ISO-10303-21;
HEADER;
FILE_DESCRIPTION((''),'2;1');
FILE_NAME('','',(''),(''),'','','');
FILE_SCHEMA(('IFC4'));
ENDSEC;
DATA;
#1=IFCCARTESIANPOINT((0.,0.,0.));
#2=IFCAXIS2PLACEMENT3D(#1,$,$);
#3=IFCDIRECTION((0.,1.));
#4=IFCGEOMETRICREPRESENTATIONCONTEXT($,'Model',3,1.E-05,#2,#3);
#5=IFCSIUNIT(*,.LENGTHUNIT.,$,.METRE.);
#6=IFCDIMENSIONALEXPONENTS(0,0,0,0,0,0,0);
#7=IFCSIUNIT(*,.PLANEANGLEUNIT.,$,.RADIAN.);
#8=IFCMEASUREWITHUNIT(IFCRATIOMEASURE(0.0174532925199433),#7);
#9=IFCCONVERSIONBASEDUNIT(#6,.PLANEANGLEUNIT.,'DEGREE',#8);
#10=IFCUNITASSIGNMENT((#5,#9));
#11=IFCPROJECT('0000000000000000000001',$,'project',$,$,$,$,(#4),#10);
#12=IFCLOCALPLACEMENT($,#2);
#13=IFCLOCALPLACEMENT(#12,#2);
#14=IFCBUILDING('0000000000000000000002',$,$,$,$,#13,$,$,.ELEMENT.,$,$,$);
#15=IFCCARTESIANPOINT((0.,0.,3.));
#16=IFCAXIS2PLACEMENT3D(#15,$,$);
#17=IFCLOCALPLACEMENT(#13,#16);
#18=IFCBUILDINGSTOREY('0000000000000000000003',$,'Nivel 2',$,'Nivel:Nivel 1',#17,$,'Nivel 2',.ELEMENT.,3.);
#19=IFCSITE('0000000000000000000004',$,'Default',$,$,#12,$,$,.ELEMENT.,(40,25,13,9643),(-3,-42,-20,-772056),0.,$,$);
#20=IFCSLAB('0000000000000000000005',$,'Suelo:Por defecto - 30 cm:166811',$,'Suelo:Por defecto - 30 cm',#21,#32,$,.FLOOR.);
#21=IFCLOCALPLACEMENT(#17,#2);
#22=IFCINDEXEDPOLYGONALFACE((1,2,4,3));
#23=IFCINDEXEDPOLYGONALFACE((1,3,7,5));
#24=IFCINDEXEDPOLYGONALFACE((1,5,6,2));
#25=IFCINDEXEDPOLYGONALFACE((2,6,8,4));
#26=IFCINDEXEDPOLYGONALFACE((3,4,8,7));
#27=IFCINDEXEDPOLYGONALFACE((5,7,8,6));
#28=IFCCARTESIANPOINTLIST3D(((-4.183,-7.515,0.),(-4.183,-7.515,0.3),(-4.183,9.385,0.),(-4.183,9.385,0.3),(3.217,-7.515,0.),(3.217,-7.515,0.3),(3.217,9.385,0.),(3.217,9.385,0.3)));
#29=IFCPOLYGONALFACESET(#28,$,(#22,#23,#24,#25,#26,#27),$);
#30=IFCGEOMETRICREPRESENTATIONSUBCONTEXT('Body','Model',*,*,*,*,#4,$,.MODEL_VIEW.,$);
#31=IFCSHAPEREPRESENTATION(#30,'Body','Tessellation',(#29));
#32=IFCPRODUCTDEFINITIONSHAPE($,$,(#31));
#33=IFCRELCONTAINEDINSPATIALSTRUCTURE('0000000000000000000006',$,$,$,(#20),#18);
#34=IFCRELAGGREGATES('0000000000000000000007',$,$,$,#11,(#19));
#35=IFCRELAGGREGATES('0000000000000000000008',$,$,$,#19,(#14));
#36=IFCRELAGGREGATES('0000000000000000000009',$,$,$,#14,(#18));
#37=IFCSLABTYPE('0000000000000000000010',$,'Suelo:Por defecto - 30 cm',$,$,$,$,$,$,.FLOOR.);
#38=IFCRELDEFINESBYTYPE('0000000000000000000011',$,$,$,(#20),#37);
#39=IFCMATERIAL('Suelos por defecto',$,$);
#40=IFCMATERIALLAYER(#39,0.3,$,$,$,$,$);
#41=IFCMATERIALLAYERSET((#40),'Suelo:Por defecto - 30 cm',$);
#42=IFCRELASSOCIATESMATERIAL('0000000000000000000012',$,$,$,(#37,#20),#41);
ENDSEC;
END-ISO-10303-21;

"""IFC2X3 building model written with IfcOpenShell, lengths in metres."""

from ifc_helpers import new_model, entity, si_unit, converted_unit, direction, frame, origin, origin_2d_with_axis, place, context, subcontext, project, spatial, rectangle, extrude, material, layer, layer_set, layer_usage, type_object, element, save


model = new_model("IFC2X3")

# Units and contexts
model_context = context("Model", 3, precision=1e-05, world=origin(), true_north=direction((0.0, 1.0)))
body_context = subcontext(model_context, "Body", "Model", "MODEL_VIEW")
ifc_project = project(units=[si_unit("LENGTHUNIT", "METRE"), converted_unit("PLANEANGLEUNIT", "DEGREE", entity("IfcRatioMeasure", 0.0174532925199433), si_unit("PLANEANGLEUNIT", "RADIAN"), dimensions=[0, 0, 0, 0, 0, 0, 0])], contexts=[model_context])

# Site, building, storey
site_placement = place(None, origin())
site = spatial("IfcSite", under=ifc_project, at=site_placement, Name="Default", CompositionType="ELEMENT", RefLatitude=(40, 25, 13, 9643), RefLongitude=(-3, -42, -20, -772056), RefElevation=0.0)
building_placement = place(site_placement, origin())
building = spatial("IfcBuilding", under=site, at=building_placement, CompositionType="ELEMENT")
storey_placement = place(building_placement, frame((0.0, 0.0, 3.0)))
storey = spatial("IfcBuildingStorey", under=building, at=storey_placement, Name="Nivel 2", ObjectType="Nivel:Nivel 1", LongName="Nivel 2", CompositionType="ELEMENT", Elevation=3.0)

# Slab
ifc_material = material(Name="Suelos por defecto")
ifc_layer = layer(ifc_material, 0.3)
ifc_layer_set = layer_set([ifc_layer], Name="Suelo:Por defecto - 30 cm")
ifc_layer_usage = layer_usage(ifc_layer_set, "AXIS3", "POSITIVE", 0.0)
slab_type = type_object("IfcSlabType", Name="Suelo:Por defecto - 30 cm", PredefinedType="FLOOR", material=ifc_layer_set)
slab_placement = place(storey_placement, origin())
element("IfcSlab", 1, at=slab_placement, inside=storey, type_object=slab_type, material=ifc_layer_usage, Name="Suelo:Por defecto - 30 cm:166811", ObjectType="Suelo:Por defecto - 30 cm", PredefinedType="FLOOR", context=body_context, shape_type="SweptSolid", body=[
    extrude(rectangle(XDim=16.9, YDim=7.4, at=origin_2d_with_axis()), frame((-0.483, 0.935, 0.3), z_axis=(0.0, 0.0, -1.0), x_axis=(0.0, 1.0, 0.0)), (0.0, 0.0, 1.0), 0.3),
])

save(model, "model.ifc")
